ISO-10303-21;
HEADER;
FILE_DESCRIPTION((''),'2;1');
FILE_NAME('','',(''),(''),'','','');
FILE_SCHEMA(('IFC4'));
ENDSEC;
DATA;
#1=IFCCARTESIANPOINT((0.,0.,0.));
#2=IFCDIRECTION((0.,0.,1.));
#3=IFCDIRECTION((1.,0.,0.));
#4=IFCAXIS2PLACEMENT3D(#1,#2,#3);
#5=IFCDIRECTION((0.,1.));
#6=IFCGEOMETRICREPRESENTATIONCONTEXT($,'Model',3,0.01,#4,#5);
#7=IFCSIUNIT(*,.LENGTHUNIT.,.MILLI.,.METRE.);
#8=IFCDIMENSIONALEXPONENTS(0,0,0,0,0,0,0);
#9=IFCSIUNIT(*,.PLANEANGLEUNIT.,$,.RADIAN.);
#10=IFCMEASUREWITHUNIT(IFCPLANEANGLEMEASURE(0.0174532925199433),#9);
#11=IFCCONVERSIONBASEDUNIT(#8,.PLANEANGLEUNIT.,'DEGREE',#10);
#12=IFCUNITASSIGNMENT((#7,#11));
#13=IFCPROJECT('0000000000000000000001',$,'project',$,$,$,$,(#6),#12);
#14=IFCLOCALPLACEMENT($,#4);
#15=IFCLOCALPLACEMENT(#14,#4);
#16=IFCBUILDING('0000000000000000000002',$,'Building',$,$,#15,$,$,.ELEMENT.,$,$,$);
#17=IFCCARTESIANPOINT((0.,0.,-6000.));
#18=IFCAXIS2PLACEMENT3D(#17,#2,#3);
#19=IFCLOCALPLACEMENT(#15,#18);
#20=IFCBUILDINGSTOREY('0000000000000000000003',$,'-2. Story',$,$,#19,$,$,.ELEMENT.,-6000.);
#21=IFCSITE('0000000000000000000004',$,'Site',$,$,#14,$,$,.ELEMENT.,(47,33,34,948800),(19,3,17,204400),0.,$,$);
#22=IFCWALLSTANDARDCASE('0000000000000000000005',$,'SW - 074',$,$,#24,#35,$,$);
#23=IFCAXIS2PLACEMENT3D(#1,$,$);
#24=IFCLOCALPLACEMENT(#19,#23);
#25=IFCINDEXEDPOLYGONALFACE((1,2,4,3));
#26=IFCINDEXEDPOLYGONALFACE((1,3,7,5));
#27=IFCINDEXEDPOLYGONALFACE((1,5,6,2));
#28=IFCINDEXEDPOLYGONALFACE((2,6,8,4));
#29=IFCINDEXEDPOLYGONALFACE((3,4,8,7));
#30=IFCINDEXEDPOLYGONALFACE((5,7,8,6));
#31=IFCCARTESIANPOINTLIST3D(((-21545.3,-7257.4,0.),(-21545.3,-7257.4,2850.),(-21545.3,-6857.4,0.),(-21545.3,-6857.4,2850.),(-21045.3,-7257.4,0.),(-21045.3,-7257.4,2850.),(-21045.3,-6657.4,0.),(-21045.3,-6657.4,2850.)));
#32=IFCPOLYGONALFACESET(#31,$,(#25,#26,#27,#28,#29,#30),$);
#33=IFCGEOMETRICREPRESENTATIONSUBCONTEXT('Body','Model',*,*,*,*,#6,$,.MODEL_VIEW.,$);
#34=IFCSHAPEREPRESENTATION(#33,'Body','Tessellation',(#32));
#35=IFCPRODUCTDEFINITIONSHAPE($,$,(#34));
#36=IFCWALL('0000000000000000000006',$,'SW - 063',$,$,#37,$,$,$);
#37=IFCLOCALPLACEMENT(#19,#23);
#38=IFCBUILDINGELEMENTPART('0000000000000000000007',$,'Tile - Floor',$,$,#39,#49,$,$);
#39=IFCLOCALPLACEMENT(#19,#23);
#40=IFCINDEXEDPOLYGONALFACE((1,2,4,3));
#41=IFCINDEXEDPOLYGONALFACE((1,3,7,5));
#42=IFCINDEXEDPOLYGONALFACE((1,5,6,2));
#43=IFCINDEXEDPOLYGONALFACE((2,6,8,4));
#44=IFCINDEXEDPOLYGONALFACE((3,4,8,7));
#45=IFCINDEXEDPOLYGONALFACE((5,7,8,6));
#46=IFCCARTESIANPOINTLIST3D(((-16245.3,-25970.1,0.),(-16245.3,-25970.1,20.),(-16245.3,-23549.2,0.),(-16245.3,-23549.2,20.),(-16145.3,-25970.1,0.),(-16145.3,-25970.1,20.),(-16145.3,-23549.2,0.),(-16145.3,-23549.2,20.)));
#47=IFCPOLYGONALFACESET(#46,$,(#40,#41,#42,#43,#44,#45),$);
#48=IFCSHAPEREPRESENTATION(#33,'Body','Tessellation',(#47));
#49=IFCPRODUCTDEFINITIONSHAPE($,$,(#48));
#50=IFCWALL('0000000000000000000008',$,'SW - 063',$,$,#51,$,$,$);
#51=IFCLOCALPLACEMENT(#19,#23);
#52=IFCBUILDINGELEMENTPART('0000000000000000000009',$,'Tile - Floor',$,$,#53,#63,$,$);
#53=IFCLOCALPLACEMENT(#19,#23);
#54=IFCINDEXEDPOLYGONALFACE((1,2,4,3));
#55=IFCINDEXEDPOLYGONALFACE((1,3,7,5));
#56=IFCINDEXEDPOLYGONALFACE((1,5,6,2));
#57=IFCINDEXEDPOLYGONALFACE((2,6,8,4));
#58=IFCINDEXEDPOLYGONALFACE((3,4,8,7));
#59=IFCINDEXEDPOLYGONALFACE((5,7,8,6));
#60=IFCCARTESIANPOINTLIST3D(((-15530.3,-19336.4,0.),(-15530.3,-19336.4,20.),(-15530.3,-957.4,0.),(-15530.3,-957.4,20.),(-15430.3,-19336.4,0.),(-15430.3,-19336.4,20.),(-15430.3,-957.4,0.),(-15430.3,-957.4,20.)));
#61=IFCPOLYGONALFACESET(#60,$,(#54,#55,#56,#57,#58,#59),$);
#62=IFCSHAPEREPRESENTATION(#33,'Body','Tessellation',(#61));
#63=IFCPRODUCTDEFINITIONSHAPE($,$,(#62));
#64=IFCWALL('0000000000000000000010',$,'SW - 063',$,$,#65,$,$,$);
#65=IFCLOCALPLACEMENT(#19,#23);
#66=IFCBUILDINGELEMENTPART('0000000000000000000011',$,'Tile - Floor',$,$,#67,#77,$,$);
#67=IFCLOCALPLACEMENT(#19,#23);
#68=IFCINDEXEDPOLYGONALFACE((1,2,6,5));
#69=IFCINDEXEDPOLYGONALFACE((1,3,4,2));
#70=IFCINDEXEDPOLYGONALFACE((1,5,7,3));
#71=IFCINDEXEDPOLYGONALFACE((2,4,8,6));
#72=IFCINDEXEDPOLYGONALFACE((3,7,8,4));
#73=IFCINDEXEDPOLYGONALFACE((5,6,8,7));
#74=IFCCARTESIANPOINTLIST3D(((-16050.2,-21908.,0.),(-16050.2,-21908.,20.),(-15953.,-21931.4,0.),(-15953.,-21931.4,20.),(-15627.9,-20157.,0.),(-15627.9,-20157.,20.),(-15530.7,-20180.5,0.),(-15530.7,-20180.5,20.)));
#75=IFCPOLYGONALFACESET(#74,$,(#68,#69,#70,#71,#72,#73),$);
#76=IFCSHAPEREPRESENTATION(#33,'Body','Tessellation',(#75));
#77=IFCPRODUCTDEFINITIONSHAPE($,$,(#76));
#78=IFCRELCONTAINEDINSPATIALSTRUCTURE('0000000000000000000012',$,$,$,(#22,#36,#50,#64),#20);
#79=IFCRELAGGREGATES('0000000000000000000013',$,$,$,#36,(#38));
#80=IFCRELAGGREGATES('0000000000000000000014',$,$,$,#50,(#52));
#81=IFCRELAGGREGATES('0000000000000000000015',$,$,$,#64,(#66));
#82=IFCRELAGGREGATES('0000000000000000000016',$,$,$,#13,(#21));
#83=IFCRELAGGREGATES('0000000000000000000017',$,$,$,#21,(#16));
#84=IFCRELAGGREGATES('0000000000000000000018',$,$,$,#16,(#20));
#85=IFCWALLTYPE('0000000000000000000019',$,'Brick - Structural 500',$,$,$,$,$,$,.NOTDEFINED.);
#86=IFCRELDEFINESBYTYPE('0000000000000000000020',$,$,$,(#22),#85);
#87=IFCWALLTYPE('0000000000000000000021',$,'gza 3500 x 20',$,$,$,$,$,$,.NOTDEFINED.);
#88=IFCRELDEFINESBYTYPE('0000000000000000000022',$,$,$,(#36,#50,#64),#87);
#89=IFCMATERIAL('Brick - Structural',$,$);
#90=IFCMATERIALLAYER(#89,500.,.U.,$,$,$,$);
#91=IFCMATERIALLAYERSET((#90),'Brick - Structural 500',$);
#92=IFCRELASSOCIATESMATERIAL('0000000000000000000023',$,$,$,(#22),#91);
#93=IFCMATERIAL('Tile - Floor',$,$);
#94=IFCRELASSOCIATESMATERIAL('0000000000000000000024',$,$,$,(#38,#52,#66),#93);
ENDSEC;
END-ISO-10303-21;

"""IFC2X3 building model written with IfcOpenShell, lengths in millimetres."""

from ifc_helpers import new_model, entity, si_unit, converted_unit, direction, frame, origin_with_axes, place, context, subcontext, project, spatial, polyline, outline, extrude, material, layer, layer_set, layer_usage, type_object, element, aggregate, save


model = new_model("IFC2X3")

# Units and contexts
model_context = context("Model", 3, precision=0.01, world=origin_with_axes(), true_north=direction((0.0, 1.0)))
body_context = subcontext(model_context, "Body", "Model", "MODEL_VIEW")
ifc_project = project(units=[si_unit("LENGTHUNIT", "METRE", prefix="MILLI"), converted_unit("PLANEANGLEUNIT", "DEGREE", entity("IfcPlaneAngleMeasure", 0.0174532925199433), si_unit("PLANEANGLEUNIT", "RADIAN"), dimensions=[0, 0, 0, 0, 0, 0, 0])], contexts=[model_context])

# Site, building, storey
site_placement = place(None, origin_with_axes())
site = spatial("IfcSite", under=ifc_project, at=site_placement, Name="Site", CompositionType="ELEMENT", RefLatitude=(47, 33, 34, 948800), RefLongitude=(19, 3, 17, 204400), RefElevation=0.0)
building_placement = place(site_placement, origin_with_axes())
building = spatial("IfcBuilding", under=site, at=building_placement, Name="Building", CompositionType="ELEMENT")
storey_placement = place(building_placement, frame((0.0, 0.0, -6000.0), z_axis=(0.0, 0.0, 1.0), x_axis=(1.0, 0.0, 0.0)))
storey = spatial("IfcBuildingStorey", under=building, at=storey_placement, Name="-2. Story", CompositionType="ELEMENT", Elevation=-6000.0)

# Shared definitions
ifc_material_1 = material(Name="Brick - Structural")

# Wall
ifc_layer_1 = layer(ifc_material_1, 500.0, ventilated="UNKNOWN")
ifc_layer_set_1 = layer_set([ifc_layer_1], Name="Brick - Structural 500")
wall_type_1 = type_object("IfcWallType", Name="Brick - Structural 500", PredefinedType="NOTDEFINED")
ifc_layer_usage_1 = layer_usage(ifc_layer_set_1, "AXIS2", "POSITIVE", 0.0)
wall_1_placement = place(storey_placement, frame((-21545.3, -6657.4, 0.0), z_axis=(0.0, 0.0, 1.0), x_axis=(0.0, -1.0, 0.0)))
element("IfcWallStandardCase", 1, at=wall_1_placement, inside=storey, type_object=wall_type_1, material=ifc_layer_usage_1, Name="SW - 074", context=body_context, shape_type="SweptSolid", body=[
    extrude(outline(polyline([(200.0, 0.0), (600.0, 0.0), (600.0, 500.0), (0.0, 500.0), (200.0, 0.0)])), origin_with_axes(), (0.0, 0.0, 1.0), 2850.0),
])

# Walls, building element parts
wall_type_2 = type_object("IfcWallType", Name="gza 3500 x 20", PredefinedType="NOTDEFINED")
ifc_material_2 = material(Name="Tile - Floor")
wall_2_placement = place(storey_placement, frame((-16245.3, -23549.2, 0.0), z_axis=(0.0, 0.0, 1.0), x_axis=(0.0, -1.0, 0.0)))
wall_2 = element("IfcWall", 2, at=wall_2_placement, inside=storey, type_object=wall_type_2, Name="SW - 063")
building_element_part_1_placement = place(wall_2_placement, origin_with_axes())
building_element_part_1 = element("IfcBuildingElementPart", 3, at=building_element_part_1_placement, material=ifc_material_2, Name="Tile - Floor", context=body_context, shape_type="SweptSolid", body=[
    extrude(outline(polyline([(100.0, 0.0), (100.0, 20.0), (0.0, 20.0), (0.0, 0.0), (100.0, 0.0)])), frame((0.0, 0.0, 0.0), z_axis=(1.0, 0.0, 0.0), x_axis=(0.0, 1.0, 0.0)), (0.0, 0.0, 1.0), 2420.9),
])
aggregate(wall_2, [building_element_part_1])
wall_3_placement = place(storey_placement, frame((-15530.3, -957.4, 0.0), z_axis=(0.0, 0.0, 1.0), x_axis=(0.0, -1.0, 0.0)))
wall_3 = element("IfcWall", 4, at=wall_3_placement, inside=storey, type_object=wall_type_2, Name="SW - 063")
building_element_part_2_placement = place(wall_3_placement, origin_with_axes())
building_element_part_2 = element("IfcBuildingElementPart", 5, at=building_element_part_2_placement, material=ifc_material_2, Name="Tile - Floor", context=body_context, shape_type="SweptSolid", body=[
    extrude(outline(polyline([(100.0, 0.0), (100.0, 20.0), (0.0, 20.0), (0.0, 0.0), (100.0, 0.0)])), frame((0.0, 0.0, 0.0), z_axis=(1.0, 0.0, 0.0), x_axis=(0.0, 1.0, 0.0)), (0.0, 0.0, 1.0), 18379.0),
])
aggregate(wall_3, [building_element_part_2])
wall_4_placement = place(storey_placement, frame((-16050.2, -21908.0, 0.0), z_axis=(0.0, 0.0, 1.0), x_axis=(0.234467, 0.972124, 0.0)))
wall_4 = element("IfcWall", 6, at=wall_4_placement, inside=storey, type_object=wall_type_2, Name="SW - 063")
building_element_part_3_placement = place(wall_4_placement, origin_with_axes())
building_element_part_3 = element("IfcBuildingElementPart", 7, at=building_element_part_3_placement, material=ifc_material_2, Name="Tile - Floor", context=body_context, shape_type="SweptSolid", body=[
    extrude(outline(polyline([(100.0, 0.0), (100.0, 20.0), (0.0, 20.0), (0.0, 0.0), (100.0, 0.0)])), frame((0.0, 0.0, 0.0), z_axis=(-1.0, 0.0, 0.0), x_axis=(0.0, -1.0, 0.0)), (0.0, 0.0, -1.0), 1801.1),
])
aggregate(wall_4, [building_element_part_3])

save(model, "model.ifc")
